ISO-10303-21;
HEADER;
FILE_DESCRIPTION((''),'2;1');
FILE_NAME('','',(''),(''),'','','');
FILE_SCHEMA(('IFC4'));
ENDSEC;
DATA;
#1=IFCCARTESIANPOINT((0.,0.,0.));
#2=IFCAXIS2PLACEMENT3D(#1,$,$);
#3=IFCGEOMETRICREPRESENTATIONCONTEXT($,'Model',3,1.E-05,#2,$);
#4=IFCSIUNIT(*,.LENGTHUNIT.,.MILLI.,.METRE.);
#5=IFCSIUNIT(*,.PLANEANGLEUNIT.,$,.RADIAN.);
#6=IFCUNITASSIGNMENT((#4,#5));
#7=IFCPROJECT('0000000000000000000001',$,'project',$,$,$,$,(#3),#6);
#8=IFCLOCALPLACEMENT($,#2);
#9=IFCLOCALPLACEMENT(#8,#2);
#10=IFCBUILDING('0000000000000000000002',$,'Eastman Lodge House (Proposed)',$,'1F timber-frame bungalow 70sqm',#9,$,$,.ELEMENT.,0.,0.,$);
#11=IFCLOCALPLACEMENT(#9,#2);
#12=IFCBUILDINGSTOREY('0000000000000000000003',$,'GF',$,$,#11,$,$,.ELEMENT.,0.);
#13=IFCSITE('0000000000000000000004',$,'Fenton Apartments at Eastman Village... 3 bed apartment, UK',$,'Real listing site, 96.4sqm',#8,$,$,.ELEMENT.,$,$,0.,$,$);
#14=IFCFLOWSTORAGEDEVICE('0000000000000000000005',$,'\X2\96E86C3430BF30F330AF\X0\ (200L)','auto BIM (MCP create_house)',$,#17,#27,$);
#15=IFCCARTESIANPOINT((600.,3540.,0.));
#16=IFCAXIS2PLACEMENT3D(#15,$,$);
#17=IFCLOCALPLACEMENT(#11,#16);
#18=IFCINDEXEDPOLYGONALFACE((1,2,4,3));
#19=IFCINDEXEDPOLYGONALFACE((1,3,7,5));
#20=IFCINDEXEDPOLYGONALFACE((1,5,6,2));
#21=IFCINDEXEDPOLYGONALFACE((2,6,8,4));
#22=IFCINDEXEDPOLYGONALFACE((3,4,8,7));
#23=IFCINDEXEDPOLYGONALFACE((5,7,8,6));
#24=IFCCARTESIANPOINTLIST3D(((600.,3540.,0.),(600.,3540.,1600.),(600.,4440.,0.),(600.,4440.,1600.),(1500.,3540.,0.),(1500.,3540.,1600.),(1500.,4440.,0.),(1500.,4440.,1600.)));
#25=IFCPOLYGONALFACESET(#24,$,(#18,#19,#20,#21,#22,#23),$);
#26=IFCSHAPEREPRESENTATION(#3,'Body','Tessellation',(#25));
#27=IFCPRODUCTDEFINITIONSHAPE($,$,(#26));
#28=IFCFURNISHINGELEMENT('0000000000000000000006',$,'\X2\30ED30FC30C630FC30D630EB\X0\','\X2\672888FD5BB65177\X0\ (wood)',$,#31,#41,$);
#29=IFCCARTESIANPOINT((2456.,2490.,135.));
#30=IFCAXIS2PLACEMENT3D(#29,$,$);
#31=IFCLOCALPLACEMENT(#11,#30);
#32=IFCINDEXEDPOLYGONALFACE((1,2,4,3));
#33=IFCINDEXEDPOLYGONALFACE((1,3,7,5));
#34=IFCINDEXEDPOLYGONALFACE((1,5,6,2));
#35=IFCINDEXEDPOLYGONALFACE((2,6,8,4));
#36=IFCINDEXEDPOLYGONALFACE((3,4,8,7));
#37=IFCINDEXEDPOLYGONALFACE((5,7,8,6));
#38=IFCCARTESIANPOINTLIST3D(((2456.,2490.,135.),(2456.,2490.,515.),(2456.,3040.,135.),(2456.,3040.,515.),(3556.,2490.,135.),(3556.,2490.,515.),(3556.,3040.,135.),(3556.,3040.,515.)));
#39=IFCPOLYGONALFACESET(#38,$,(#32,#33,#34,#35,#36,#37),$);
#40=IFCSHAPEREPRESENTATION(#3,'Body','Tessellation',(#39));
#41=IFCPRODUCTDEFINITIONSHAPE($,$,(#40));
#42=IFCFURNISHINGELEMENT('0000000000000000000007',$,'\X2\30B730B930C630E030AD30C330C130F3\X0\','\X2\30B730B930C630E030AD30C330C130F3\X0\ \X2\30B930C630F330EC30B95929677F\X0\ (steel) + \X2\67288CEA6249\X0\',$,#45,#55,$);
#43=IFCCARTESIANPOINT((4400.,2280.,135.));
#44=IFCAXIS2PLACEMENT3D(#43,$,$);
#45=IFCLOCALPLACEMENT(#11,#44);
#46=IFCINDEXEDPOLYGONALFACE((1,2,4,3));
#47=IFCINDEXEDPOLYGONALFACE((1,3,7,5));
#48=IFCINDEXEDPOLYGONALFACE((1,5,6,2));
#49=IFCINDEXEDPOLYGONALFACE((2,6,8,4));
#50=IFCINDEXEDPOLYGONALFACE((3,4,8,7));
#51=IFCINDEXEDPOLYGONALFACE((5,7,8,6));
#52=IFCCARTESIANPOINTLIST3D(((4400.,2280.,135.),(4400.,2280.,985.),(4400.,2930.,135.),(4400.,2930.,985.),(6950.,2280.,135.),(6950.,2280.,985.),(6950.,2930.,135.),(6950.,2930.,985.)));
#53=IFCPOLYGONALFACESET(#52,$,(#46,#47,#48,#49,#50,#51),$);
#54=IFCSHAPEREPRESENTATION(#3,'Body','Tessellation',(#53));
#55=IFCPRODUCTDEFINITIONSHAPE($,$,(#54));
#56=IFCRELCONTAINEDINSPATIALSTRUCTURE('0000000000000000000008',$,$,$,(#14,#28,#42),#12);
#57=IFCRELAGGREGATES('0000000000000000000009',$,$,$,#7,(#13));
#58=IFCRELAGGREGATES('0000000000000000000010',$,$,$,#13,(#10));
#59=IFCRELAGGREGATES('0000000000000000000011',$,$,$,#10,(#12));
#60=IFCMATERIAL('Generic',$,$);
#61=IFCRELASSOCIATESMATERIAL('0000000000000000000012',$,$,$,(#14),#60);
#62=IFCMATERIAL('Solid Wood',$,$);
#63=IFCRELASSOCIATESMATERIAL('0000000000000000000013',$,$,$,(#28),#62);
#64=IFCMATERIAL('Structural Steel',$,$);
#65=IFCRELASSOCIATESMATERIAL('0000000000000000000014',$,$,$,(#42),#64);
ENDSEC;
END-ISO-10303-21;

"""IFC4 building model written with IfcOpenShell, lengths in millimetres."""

from ifc_helpers import new_model, si_unit, frame, frame_2d, origin, place, context, project, spatial, rectangle, extrude, material, element, save


model = new_model("IFC4")

# Units and contexts
model_context = context("Model", 3, precision=1e-05, world=origin())
ifc_project = project(units=[si_unit("LENGTHUNIT", "METRE", prefix="MILLI"), si_unit("PLANEANGLEUNIT", "RADIAN")], contexts=[model_context])

# Site, building, storey
site_placement = place(None, origin())
site = spatial("IfcSite", under=ifc_project, at=site_placement, Name="Fenton Apartments at Eastman Village... 3 bed apartment, UK", ObjectType="Real listing site, 96.4sqm", CompositionType="ELEMENT", RefElevation=0.0)
building_placement = place(site_placement, origin())
building = spatial("IfcBuilding", under=site, at=building_placement, Name="Eastman Lodge House (Proposed)", ObjectType="1F timber-frame bungalow 70sqm", CompositionType="ELEMENT", ElevationOfRefHeight=0.0, ElevationOfTerrain=0.0)
storey_placement = place(building_placement, origin())
storey = spatial("IfcBuildingStorey", under=building, at=storey_placement, Name="GF", CompositionType="ELEMENT", Elevation=0.0)

# Shared definitions
ifc_material_1 = material(Name="Solid Wood")

# Shared definitions
ifc_material_2 = material(Name="Generic")

# Flow storage device
flow_storage_device_placement = place(storey_placement, frame((600.0, 3540.0, 0.0)))
element("IfcFlowStorageDevice", 1, at=flow_storage_device_placement, inside=storey, material=ifc_material_2, Name="雨水タンク (200L)", Description="auto BIM (MCP create_house)", context=model_context, shape_type="SweptSolid", body=[
    extrude(rectangle(XDim=900.0, YDim=900.0, at=frame_2d((450.0, 450.0))), frame((600.0, 3540.0, 0.0)), (0.0, 0.0, 1.0), 1600.0),
])

# Furnishing elements
furnishing_1_placement = place(storey_placement, frame((2456.0, 2490.0, 135.0)))
element("IfcFurnishingElement", 2, at=furnishing_1_placement, inside=storey, material=ifc_material_1, Name="ローテーブル", Description="木製家具 (wood)", context=model_context, shape_type="SweptSolid", body=[
    extrude(rectangle(XDim=1100.0, YDim=550.0, at=frame_2d((550.0, 275.0))), frame((2456.0, 2490.0, 135.0)), (0.0, 0.0, 1.0), 380.0),
])
ifc_material_3 = material(Name="Structural Steel")
furnishing_2_placement = place(storey_placement, frame((4400.0, 2280.0, 135.0)))
element("IfcFurnishingElement", 3, at=furnishing_2_placement, inside=storey, material=ifc_material_3, Name="システムキッチン", Description="システムキッチン ステンレス天板 (steel) + 木質扉", context=model_context, shape_type="SweptSolid", body=[
    extrude(rectangle(XDim=2550.0, YDim=650.0, at=frame_2d((1275.0, 325.0))), frame((4400.0, 2280.0, 135.0)), (0.0, 0.0, 1.0), 850.0),
])

save(model, "model.ifc")
